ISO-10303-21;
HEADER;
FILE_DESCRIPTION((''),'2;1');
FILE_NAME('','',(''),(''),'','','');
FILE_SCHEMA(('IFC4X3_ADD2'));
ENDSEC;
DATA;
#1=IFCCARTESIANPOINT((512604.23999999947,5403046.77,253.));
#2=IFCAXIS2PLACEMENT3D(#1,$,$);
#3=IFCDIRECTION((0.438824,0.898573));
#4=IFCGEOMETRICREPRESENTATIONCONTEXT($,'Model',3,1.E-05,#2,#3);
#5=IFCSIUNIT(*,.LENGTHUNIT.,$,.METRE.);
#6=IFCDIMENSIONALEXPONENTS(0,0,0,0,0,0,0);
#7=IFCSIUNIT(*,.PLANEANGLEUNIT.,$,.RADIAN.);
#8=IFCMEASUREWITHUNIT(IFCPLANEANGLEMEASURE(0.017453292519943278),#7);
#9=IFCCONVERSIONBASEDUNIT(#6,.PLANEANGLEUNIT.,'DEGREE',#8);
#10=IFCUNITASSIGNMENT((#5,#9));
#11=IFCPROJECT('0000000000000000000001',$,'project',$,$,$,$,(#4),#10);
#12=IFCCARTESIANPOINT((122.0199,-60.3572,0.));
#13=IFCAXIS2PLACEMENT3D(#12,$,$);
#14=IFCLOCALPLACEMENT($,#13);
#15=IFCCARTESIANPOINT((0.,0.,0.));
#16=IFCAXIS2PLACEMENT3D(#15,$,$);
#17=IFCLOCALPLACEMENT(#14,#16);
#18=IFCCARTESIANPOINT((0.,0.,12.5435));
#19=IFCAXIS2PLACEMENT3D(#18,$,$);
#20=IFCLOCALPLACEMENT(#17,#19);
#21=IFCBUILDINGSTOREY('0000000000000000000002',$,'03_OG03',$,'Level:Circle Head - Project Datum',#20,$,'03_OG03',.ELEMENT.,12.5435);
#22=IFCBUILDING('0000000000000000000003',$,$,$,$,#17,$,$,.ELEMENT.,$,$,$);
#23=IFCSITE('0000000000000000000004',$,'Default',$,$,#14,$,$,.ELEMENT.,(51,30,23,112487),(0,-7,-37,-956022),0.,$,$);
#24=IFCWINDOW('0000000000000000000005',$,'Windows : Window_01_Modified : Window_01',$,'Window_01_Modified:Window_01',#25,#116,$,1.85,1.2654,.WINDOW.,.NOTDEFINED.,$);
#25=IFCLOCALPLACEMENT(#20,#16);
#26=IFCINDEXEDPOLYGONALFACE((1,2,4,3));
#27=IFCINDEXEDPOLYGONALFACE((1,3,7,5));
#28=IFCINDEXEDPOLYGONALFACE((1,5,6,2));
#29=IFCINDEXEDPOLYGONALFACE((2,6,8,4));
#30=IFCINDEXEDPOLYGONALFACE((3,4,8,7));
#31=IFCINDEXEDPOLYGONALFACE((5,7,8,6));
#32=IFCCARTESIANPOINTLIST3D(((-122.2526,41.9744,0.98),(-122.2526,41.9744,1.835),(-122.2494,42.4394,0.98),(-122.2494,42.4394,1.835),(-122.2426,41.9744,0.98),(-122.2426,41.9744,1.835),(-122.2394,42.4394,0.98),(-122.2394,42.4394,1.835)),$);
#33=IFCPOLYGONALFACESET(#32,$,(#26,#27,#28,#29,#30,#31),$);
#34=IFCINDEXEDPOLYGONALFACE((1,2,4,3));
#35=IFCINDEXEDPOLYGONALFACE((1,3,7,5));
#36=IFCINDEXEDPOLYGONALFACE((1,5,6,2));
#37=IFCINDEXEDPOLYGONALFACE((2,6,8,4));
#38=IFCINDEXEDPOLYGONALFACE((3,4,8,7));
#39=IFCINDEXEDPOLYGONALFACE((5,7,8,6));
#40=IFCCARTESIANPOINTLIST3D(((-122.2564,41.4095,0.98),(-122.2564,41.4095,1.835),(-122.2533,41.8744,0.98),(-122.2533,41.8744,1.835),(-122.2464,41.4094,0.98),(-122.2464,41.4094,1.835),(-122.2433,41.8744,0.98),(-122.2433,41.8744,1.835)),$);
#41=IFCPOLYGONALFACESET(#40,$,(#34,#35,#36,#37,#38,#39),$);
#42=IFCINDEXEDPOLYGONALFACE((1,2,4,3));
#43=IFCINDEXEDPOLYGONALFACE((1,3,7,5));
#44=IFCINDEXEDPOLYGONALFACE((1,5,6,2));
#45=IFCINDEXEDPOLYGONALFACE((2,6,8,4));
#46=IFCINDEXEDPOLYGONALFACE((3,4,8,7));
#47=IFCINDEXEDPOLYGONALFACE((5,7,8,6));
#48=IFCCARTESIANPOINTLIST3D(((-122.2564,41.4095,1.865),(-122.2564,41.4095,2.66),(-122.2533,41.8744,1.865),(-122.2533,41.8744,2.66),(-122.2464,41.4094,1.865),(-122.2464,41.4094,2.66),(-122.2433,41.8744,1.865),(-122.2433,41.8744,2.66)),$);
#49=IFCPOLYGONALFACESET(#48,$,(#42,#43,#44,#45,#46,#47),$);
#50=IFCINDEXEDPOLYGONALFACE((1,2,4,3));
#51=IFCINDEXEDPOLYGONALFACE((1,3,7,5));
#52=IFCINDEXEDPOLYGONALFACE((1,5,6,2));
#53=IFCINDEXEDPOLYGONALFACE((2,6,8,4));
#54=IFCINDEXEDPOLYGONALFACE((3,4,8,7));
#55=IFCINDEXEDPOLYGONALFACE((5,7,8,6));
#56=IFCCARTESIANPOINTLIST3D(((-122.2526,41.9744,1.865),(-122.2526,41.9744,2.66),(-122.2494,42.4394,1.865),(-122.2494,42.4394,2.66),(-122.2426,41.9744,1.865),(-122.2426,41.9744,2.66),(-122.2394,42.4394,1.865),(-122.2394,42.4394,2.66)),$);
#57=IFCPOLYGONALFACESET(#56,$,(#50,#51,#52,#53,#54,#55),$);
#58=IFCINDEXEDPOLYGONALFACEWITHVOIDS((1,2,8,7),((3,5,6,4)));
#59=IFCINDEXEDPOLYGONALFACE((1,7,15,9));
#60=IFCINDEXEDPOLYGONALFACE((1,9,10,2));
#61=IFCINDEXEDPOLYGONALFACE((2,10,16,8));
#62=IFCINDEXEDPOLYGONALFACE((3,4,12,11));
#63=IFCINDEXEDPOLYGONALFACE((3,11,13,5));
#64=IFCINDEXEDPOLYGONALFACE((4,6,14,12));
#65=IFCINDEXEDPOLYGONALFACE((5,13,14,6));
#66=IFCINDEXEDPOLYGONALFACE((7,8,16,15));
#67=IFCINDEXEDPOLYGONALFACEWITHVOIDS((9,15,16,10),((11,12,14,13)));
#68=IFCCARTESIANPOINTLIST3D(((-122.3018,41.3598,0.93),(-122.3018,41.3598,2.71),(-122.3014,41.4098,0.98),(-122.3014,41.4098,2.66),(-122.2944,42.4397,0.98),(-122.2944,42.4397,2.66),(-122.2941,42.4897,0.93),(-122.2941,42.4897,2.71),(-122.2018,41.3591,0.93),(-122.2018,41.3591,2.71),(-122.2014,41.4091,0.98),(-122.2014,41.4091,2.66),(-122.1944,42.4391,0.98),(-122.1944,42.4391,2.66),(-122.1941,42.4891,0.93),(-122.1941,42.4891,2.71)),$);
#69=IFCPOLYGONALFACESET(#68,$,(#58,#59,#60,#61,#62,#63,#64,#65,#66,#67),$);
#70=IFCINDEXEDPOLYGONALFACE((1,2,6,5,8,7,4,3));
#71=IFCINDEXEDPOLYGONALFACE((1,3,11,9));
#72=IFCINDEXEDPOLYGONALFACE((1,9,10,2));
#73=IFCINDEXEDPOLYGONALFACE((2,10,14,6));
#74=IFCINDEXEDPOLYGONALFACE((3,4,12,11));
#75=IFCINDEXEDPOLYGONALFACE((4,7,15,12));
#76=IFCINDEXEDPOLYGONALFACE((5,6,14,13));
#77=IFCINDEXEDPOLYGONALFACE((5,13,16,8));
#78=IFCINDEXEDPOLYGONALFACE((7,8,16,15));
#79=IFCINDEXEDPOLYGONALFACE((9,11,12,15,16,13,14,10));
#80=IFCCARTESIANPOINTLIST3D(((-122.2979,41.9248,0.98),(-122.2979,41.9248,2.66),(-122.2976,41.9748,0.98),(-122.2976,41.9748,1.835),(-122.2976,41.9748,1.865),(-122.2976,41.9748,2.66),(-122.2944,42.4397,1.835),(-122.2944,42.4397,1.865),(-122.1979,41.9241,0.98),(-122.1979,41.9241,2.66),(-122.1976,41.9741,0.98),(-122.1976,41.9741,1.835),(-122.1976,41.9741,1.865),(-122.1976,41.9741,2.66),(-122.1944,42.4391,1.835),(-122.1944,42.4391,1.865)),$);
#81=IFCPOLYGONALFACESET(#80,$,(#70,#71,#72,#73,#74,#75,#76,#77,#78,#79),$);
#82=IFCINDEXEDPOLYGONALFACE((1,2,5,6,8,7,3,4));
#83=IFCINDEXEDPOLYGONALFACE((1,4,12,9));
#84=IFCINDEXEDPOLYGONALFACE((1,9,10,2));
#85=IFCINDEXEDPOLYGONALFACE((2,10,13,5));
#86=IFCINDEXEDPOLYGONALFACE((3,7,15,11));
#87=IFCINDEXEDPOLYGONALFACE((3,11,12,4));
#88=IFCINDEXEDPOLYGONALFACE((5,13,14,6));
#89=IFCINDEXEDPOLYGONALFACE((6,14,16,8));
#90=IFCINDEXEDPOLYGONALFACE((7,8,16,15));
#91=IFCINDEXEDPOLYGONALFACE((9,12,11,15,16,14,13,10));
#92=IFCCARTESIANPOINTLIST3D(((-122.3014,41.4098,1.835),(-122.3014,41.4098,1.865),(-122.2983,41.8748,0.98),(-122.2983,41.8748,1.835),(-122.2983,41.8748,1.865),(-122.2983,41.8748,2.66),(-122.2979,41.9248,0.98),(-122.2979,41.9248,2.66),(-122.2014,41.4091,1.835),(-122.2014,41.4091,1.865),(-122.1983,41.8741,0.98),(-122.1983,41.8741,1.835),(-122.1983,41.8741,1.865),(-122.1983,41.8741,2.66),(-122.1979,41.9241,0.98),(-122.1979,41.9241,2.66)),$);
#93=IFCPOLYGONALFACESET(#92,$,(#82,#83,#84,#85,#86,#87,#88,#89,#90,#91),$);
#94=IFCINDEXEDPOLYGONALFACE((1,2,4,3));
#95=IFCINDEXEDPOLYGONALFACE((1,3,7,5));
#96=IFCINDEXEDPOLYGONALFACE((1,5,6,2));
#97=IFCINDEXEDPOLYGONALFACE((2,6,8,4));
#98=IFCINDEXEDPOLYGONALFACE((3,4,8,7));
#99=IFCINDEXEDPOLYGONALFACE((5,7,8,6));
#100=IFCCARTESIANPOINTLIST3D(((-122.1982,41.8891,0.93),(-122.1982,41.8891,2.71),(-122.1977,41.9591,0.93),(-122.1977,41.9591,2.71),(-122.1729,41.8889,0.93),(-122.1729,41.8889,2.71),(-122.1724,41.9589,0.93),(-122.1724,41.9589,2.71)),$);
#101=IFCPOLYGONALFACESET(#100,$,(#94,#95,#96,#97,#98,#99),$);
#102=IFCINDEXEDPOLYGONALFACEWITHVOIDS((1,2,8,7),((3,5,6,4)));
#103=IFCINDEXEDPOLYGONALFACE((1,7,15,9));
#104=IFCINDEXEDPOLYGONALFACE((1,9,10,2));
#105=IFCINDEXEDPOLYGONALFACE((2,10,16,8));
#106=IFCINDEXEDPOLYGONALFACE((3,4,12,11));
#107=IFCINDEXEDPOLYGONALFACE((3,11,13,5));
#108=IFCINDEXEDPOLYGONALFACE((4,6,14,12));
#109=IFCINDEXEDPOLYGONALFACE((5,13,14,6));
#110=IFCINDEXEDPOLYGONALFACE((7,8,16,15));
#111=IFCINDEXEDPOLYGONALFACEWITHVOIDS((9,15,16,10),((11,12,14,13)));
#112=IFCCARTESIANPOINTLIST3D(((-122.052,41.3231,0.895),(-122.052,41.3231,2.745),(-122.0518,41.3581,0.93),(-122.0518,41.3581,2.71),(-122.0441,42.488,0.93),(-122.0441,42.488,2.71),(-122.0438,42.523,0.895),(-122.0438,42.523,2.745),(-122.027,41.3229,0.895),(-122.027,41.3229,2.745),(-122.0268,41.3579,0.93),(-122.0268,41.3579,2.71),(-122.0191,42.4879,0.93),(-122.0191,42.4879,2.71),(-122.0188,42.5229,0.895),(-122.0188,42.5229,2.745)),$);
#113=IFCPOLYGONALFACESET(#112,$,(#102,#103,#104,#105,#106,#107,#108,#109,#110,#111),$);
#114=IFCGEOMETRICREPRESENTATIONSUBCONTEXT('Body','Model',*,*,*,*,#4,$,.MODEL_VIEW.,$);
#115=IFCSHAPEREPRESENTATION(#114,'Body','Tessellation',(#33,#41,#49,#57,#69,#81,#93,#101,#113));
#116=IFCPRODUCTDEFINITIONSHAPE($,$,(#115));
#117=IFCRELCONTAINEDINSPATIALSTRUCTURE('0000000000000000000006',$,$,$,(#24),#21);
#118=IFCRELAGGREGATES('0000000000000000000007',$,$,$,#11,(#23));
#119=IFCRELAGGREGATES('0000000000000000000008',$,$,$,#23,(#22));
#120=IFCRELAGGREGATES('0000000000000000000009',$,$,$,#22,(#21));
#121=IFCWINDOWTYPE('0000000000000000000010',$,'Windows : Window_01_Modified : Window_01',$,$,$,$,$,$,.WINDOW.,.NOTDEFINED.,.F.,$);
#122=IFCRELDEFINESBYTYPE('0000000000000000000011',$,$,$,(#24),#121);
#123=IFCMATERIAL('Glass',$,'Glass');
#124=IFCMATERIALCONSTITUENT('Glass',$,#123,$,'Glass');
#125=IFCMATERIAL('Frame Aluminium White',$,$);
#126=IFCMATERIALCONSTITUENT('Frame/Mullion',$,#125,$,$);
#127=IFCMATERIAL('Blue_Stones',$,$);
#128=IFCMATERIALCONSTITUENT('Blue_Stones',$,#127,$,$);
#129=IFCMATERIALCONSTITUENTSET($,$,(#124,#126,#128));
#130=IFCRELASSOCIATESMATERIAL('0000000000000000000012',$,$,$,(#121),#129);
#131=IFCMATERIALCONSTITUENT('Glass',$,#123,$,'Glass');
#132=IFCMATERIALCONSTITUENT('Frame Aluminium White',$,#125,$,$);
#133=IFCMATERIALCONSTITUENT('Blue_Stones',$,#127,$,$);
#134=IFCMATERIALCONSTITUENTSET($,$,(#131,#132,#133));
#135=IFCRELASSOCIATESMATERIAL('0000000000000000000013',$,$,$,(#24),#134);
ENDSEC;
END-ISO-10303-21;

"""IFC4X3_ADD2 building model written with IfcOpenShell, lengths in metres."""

from ifc_helpers import new_model, entity, si_unit, converted_unit, direction, frame, frame_2d, origin, place, context, subcontext, project, spatial, polyline, rectangle, outline, extrude, source, transform, mapped, material, constituent, constituent_set, type_object, type_shapes, element, save


model = new_model("IFC4X3_ADD2")

# Units and contexts
model_context = context("Model", 3, precision=1e-05, world=frame((512604.23999999947, 5403046.77, 253.0)), true_north=direction((0.438824, 0.898573)))
body_context = subcontext(model_context, "Body", "Model", "MODEL_VIEW")
ifc_project = project(units=[si_unit("LENGTHUNIT", "METRE"), converted_unit("PLANEANGLEUNIT", "DEGREE", entity("IfcPlaneAngleMeasure", 0.017453292519943278), si_unit("PLANEANGLEUNIT", "RADIAN"), dimensions=[0, 0, 0, 0, 0, 0, 0])], contexts=[model_context])

# Site, building, storey
site_placement = place(None, frame((122.0199, -60.3572, 0.0)))
site = spatial("IfcSite", under=ifc_project, at=site_placement, Name="Default", CompositionType="ELEMENT", RefLatitude=(51, 30, 23, 112487), RefLongitude=(0, -7, -37, -956022), RefElevation=0.0)
building_placement = place(site_placement, origin())
building = spatial("IfcBuilding", under=site, at=building_placement, CompositionType="ELEMENT")
storey_placement = place(building_placement, frame((0.0, 0.0, 12.5435)))
storey = spatial("IfcBuildingStorey", under=building, at=storey_placement, Name="03_OG03", ObjectType="Level:Circle Head - Project Datum", LongName="03_OG03", CompositionType="ELEMENT", Elevation=12.5435)

# Window
ifc_material_1 = material(Name="Glass", Category="Glass")
ifc_material_2 = material(Name="Frame Aluminium White")
ifc_material_3 = material(Name="Blue_Stones")
ifc_constituent_1 = constituent(ifc_material_1, Name="Glass", Category="Glass")
ifc_constituent_2 = constituent(ifc_material_2, Name="Frame Aluminium White")
ifc_constituent_3 = constituent(ifc_material_3, Name="Blue_Stones")
ifc_constituent_set_1 = constituent_set(constituents=[ifc_constituent_1, ifc_constituent_2, ifc_constituent_3])
ifc_constituent_4 = constituent(ifc_material_1, Name="Glass", Category="Glass")
ifc_constituent_5 = constituent(ifc_material_2, Name="Frame/Mullion")
ifc_constituent_6 = constituent(ifc_material_3, Name="Blue_Stones")
ifc_constituent_set_2 = constituent_set(constituents=[ifc_constituent_4, ifc_constituent_5, ifc_constituent_6])
window_type_1 = type_object("IfcWindowType", Name="Windows : Window_01_Modified : Window_01", ParameterTakesPrecedence=False, PartitioningType="NOTDEFINED", PredefinedType="WINDOW", material=ifc_constituent_set_2)
shared_shape_1 = source(origin(), body_context, "Body", "SweptSolid", [
    extrude(rectangle(XDim=0.465, YDim=0.01, at=frame_2d((0.0, 0.0), x_axis=(1.0, 0.0))), frame((0.3476, -0.2, 0.0514), z_axis=(0.0, 0.0, 1.0), x_axis=(-1.0, 0.0, 0.0)), (0.0, 0.0, 1.0), 0.855),
    extrude(rectangle(XDim=0.01, YDim=0.465, at=frame_2d((0.0, 0.0), x_axis=(1.0, 0.0))), frame((0.9126, -0.2, 0.0514), z_axis=(0.0, 0.0, 1.0), x_axis=(0.0, 1.0, 0.0)), (0.0, 0.0, 1.0), 0.855),
    extrude(rectangle(XDim=0.465, YDim=0.01, at=frame_2d((0.0, 0.0), x_axis=(1.0, 0.0))), frame((0.9126, -0.2, 0.9364), z_axis=(0.0, 0.0, 1.0), x_axis=(-1.0, 0.0, 0.0)), (0.0, 0.0, 1.0), 0.795),
    extrude(rectangle(XDim=0.465, YDim=0.01, at=frame_2d((0.0, 0.0), x_axis=(1.0, 0.0))), frame((0.3476, -0.2, 0.9364), z_axis=(0.0, 0.0, 1.0), x_axis=(-1.0, 0.0, 0.0)), (0.0, 0.0, 1.0), 0.795),
    extrude(outline(polyline([(-0.89, -0.565), (0.89, -0.565), (0.89, 0.565), (-0.89, 0.565), (-0.89, -0.565)]), holes=[polyline([(0.84, 0.515), (0.84, -0.515), (-0.84, -0.515), (-0.84, 0.515), (0.84, 0.515)])]), frame((0.6301, -0.25, 0.8914), z_axis=(0.0, 1.0, 0.0), x_axis=(0.0, 0.0, 1.0)), (0.0, 0.0, 1.0), 0.1),
    extrude(outline(polyline([(0.03, 0.1037), (0.825, 0.1037), (0.825, 0.1538), (-0.855, 0.1538), (-0.855, 0.1037), (0.0, 0.1037), (0.0, -0.3613), (0.03, -0.3613), (0.03, 0.1037)])), frame((0.4763, -0.25, 0.9064), z_axis=(0.0, 1.0, 0.0), x_axis=(0.0, 0.0, 1.0)), (0.0, 0.0, 1.0), 0.1),
    extrude(outline(polyline([(-0.825, -0.1038), (-0.825, -0.1538), (0.855, -0.1538), (0.855, -0.1038), (0.0, -0.1038), (0.0, 0.3613), (-0.03, 0.3613), (-0.03, -0.1038), (-0.825, -0.1038)])), frame((0.7838, -0.25, 0.9064), z_axis=(0.0, -1.0, 0.0), x_axis=(0.0, 0.0, -1.0)), (0.0, 0.0, -1.0), 0.1),
    extrude(rectangle(XDim=0.0253, YDim=0.07, at=frame_2d((0.0, 0.0), x_axis=(1.0, 0.0))), frame((0.6301, -0.1374, 0.0014), z_axis=(0.0, 0.0, 1.0), x_axis=(0.0, -1.0, 0.0)), (0.0, 0.0, 1.0), 1.78),
    extrude(outline(polyline([(-0.6, -0.925), (0.6, -0.925), (0.6, 0.925), (-0.6, 0.925), (-0.6, -0.925)]), holes=[polyline([(-0.565, -0.89), (-0.565, 0.89), (0.565, 0.89), (0.565, -0.89), (-0.565, -0.89)])]), frame((0.6301, 0.0, 0.8914), z_axis=(0.0, 1.0, 0.0), x_axis=(1.0, 0.0, 0.0)), (0.0, 0.0, 1.0), 0.025),
])
type_shapes(window_type_1, [shared_shape_1])
window_1_placement = place(storey_placement, frame((-122.0436, 42.5531, 0.9286), z_axis=(0.0, 0.0, 1.0), x_axis=(-0.0068, -0.999977, 0.0)))
element("IfcWindow", 1, at=window_1_placement, inside=storey, type_object=window_type_1, material=ifc_constituent_set_1, Name="Windows : Window_01_Modified : Window_01", ObjectType="Window_01_Modified:Window_01", OverallHeight=1.85, OverallWidth=1.2654, PartitioningType="NOTDEFINED", PredefinedType="WINDOW", context=body_context, shape_type="MappedRepresentation", body=[
    mapped(shared_shape_1, transform((0.0, 0.0, 0.0), scale=1.0)),
])

save(model, "model.ifc")
